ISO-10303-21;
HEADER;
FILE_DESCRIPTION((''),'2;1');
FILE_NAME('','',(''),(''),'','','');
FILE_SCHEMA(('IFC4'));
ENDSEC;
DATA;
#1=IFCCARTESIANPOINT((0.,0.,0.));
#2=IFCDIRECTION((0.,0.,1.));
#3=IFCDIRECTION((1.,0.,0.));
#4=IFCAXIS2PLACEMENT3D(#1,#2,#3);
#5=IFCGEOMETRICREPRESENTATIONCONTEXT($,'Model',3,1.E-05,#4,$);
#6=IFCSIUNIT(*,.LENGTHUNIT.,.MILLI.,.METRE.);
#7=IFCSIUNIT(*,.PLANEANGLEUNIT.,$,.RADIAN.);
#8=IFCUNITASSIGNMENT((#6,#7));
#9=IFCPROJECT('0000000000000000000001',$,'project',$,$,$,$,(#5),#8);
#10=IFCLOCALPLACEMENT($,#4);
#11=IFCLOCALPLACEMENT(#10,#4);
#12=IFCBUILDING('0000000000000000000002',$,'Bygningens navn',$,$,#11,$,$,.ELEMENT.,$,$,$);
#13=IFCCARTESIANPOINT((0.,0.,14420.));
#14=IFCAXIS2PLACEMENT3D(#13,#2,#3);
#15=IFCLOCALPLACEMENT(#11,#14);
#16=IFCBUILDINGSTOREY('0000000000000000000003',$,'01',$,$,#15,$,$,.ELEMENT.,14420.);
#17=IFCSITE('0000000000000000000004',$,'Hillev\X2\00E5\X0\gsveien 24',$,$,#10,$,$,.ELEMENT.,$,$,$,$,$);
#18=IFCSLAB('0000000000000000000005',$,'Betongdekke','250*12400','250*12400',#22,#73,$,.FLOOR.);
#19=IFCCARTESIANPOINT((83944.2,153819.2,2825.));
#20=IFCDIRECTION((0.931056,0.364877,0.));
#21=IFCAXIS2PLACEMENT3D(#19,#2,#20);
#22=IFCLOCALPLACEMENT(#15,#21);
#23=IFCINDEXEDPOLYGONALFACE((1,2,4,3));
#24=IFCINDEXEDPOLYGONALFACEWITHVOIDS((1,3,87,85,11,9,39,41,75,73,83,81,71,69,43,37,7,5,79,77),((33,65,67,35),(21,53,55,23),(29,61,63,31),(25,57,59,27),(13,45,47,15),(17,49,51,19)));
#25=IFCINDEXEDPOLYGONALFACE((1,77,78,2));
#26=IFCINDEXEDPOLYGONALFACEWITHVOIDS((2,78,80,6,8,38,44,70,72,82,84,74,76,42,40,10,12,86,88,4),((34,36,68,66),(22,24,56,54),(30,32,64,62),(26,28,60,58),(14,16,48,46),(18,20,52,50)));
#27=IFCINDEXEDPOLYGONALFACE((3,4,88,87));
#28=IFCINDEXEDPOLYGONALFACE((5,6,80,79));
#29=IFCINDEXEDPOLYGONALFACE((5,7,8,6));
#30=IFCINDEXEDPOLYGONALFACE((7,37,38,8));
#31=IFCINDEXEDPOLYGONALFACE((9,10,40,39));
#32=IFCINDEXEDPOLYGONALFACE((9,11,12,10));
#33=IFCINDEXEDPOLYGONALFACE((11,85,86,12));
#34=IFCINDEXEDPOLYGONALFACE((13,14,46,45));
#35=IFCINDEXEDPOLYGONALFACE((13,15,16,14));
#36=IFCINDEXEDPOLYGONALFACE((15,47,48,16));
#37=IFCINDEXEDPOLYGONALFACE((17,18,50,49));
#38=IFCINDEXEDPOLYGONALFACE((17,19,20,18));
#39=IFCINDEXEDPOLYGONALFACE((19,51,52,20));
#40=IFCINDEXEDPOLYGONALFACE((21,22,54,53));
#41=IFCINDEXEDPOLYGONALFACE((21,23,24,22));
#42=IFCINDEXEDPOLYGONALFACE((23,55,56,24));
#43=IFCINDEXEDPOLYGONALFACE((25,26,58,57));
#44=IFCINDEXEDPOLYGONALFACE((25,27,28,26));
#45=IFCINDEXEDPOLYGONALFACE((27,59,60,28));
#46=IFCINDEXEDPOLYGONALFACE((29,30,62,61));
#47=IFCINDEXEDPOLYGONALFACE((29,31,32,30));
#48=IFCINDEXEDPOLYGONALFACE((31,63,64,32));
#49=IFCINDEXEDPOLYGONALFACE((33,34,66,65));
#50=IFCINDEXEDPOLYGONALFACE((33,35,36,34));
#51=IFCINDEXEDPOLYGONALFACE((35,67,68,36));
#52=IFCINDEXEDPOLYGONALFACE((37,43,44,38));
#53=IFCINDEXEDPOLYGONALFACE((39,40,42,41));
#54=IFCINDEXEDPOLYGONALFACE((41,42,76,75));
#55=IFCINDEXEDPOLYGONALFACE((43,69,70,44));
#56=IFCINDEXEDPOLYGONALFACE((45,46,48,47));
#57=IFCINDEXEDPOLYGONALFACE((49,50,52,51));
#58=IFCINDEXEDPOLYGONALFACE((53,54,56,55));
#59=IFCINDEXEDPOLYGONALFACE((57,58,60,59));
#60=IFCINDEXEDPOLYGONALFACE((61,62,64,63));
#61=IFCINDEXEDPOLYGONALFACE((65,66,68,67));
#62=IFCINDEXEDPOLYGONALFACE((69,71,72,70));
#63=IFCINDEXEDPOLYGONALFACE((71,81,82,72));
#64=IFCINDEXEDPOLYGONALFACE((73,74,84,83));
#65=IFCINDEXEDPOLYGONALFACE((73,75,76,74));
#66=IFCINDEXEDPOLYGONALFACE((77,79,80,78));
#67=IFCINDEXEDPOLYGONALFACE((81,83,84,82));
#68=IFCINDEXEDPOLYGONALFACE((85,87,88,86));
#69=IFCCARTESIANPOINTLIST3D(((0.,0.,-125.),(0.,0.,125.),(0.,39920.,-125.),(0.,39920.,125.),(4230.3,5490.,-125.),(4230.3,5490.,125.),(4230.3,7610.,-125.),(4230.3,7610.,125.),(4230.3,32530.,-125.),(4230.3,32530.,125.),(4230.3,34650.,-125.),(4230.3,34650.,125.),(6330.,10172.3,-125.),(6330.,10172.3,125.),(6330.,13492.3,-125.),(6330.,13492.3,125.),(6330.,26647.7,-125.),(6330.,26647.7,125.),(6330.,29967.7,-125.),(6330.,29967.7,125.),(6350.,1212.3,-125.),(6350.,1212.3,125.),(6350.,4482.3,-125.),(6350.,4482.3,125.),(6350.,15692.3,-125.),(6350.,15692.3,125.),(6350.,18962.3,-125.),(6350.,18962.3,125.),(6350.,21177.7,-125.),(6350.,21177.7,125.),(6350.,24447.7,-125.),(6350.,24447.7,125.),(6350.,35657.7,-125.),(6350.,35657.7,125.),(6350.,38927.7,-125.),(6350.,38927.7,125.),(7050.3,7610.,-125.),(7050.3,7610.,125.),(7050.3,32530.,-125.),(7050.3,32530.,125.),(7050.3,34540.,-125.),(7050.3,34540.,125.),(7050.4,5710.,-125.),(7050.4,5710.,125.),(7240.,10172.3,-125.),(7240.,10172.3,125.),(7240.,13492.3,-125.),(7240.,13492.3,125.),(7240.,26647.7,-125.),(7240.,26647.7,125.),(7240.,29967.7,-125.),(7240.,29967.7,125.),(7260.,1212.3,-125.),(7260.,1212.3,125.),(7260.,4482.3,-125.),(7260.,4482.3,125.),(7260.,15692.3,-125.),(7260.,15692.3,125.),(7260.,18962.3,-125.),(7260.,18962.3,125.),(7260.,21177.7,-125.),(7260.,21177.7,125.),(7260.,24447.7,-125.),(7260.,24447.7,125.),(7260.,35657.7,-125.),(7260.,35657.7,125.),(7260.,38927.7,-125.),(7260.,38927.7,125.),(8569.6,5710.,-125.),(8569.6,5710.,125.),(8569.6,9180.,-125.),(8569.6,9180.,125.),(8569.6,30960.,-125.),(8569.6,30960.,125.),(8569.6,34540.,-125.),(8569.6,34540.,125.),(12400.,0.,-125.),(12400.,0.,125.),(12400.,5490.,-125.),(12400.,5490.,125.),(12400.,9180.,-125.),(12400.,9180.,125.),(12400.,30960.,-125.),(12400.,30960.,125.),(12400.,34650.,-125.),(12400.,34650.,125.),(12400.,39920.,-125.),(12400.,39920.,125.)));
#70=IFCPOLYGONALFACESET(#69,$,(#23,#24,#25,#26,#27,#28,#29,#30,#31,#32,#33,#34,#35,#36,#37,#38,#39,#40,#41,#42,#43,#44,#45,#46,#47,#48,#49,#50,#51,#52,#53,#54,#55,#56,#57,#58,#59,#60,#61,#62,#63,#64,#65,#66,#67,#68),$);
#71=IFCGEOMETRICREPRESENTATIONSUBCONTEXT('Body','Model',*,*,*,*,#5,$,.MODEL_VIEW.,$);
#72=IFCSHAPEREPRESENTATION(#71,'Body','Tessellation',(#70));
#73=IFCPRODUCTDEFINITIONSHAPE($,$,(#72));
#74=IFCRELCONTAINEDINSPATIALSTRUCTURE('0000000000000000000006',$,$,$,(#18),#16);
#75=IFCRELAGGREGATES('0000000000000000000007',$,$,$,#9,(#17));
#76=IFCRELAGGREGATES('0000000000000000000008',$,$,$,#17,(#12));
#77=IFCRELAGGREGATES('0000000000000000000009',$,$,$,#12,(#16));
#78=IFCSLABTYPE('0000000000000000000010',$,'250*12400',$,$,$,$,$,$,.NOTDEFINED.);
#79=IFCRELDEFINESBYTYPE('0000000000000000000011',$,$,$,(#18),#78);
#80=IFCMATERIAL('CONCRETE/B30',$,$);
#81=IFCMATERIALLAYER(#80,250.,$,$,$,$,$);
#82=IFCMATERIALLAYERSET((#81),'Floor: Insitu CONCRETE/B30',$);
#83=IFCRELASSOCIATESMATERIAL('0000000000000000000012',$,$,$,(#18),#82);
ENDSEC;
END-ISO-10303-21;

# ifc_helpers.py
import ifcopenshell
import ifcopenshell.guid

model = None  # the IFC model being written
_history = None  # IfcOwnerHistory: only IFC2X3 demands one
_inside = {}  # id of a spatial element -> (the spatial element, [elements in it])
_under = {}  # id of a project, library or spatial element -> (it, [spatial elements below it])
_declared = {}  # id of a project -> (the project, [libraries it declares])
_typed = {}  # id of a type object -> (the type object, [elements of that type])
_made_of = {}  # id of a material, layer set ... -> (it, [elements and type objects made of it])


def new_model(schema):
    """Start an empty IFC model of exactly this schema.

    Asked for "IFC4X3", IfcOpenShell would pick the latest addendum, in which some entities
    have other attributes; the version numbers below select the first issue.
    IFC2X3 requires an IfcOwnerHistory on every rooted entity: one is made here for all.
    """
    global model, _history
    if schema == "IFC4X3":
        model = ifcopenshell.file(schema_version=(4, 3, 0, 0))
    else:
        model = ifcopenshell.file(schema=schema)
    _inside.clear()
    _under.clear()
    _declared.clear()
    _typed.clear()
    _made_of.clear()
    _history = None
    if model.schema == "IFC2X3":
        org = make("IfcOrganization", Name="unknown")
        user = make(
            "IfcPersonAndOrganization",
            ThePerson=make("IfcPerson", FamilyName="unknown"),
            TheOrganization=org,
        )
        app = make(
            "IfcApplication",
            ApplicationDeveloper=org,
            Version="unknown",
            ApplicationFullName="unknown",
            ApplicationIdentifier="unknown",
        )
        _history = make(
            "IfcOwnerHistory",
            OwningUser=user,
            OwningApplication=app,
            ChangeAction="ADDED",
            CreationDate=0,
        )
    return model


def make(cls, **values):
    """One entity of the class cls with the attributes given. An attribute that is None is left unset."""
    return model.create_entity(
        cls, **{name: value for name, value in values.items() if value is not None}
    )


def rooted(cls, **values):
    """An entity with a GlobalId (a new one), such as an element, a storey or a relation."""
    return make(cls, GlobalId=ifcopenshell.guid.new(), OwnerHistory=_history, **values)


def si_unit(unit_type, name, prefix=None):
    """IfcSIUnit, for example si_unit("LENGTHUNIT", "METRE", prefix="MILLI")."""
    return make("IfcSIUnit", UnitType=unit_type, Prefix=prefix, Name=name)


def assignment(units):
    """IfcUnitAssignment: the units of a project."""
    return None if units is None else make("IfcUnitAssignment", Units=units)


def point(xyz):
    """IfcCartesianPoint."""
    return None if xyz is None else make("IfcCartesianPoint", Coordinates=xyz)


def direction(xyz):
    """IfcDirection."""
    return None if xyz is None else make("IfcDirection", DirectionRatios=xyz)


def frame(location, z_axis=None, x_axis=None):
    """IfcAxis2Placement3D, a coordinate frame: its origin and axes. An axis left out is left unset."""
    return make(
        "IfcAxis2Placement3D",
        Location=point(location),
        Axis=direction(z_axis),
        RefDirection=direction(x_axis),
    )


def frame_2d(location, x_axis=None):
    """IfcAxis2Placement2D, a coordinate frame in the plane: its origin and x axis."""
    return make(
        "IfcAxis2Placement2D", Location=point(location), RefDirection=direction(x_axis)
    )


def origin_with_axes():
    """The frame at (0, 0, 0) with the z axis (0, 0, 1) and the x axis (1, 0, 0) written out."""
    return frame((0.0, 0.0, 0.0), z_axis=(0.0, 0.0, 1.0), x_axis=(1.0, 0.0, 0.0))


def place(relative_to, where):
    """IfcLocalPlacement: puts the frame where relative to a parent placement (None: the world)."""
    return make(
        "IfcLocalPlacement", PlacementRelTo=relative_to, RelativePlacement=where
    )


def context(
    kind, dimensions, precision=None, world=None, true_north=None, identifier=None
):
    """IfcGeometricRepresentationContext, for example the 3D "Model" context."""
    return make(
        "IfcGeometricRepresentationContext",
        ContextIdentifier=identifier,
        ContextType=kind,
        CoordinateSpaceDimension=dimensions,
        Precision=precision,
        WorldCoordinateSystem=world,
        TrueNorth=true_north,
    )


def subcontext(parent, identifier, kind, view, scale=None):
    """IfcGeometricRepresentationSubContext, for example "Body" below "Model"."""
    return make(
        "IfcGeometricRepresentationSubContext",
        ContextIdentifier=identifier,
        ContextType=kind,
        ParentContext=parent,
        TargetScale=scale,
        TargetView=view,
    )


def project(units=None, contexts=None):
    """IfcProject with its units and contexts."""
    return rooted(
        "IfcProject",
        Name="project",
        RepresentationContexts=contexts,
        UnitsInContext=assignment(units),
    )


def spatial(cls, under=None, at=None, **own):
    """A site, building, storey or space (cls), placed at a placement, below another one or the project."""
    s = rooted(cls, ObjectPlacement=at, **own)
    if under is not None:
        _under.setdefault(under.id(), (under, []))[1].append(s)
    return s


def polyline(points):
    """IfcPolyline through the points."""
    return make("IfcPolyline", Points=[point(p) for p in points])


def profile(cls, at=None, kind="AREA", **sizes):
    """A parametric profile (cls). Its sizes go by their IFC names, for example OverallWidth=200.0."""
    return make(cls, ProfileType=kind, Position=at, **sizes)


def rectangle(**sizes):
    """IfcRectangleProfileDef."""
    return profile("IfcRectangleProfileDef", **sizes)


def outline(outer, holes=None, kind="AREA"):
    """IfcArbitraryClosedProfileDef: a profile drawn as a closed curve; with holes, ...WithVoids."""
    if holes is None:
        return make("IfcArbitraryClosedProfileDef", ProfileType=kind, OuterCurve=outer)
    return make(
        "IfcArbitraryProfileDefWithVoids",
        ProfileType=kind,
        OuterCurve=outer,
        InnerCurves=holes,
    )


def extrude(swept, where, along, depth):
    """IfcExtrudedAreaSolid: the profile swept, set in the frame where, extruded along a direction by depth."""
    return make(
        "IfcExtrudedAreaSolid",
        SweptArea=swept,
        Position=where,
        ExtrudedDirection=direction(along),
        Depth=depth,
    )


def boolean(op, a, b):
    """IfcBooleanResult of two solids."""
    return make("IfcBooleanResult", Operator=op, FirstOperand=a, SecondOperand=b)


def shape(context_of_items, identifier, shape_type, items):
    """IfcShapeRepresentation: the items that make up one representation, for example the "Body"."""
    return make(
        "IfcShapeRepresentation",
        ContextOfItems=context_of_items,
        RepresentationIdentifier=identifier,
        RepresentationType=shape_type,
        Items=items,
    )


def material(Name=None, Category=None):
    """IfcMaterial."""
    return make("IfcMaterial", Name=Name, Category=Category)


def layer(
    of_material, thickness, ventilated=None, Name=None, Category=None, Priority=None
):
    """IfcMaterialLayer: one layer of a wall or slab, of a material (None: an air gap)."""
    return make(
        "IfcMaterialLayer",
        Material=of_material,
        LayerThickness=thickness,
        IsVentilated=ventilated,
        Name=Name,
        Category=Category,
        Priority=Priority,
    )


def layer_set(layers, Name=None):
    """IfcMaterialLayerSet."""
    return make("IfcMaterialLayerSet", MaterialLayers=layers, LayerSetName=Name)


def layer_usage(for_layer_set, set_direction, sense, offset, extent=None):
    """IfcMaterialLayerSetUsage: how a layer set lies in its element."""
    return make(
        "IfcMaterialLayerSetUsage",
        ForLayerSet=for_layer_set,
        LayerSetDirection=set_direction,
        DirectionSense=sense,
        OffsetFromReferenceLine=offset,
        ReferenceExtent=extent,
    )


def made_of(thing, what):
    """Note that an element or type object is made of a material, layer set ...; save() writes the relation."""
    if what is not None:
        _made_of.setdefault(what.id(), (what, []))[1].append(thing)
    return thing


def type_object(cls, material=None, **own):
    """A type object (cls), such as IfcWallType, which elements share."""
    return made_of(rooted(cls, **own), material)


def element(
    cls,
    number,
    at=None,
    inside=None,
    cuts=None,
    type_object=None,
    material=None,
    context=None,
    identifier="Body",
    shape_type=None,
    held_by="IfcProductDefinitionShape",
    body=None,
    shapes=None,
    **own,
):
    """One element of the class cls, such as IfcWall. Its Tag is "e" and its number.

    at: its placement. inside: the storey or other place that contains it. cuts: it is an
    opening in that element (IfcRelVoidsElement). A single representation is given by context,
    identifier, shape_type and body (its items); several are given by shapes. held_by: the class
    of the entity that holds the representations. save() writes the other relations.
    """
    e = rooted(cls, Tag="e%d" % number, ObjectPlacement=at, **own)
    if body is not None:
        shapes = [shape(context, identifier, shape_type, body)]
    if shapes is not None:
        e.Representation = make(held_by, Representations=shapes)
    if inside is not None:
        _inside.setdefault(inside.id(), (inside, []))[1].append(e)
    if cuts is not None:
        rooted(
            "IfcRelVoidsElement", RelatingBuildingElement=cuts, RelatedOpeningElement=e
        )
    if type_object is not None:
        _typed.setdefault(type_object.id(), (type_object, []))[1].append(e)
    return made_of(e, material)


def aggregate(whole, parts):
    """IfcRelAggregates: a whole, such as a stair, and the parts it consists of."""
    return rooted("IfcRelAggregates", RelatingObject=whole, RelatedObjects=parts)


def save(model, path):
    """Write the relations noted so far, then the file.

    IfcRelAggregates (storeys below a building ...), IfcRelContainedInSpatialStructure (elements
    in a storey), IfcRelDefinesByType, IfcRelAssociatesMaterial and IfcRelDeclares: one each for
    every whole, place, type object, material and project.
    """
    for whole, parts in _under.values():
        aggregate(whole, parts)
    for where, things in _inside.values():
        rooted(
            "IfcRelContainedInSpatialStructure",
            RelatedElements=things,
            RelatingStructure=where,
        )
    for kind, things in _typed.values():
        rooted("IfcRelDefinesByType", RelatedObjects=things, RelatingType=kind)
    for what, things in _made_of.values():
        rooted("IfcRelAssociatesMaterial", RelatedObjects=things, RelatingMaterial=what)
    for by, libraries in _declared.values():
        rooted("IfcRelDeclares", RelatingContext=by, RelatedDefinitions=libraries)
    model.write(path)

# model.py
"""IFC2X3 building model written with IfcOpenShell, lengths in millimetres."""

from ifc_helpers import new_model, si_unit, frame, frame_2d, origin_with_axes, place, context, subcontext, project, spatial, polyline, rectangle, outline, extrude, boolean, material, layer, layer_set, layer_usage, type_object, element, save


model = new_model("IFC2X3")

# Units and contexts
model_context = context("Model", 3, precision=1e-05, world=origin_with_axes())
body_context = subcontext(model_context, "Body", "Model", "MODEL_VIEW")
ifc_project = project(units=[si_unit("LENGTHUNIT", "METRE", prefix="MILLI"), si_unit("PLANEANGLEUNIT", "RADIAN")], contexts=[model_context])

# Site, building, storey
site_placement = place(None, origin_with_axes())
site = spatial("IfcSite", under=ifc_project, at=site_placement, Name="Hillevågsveien 24", CompositionType="ELEMENT")
building_placement = place(site_placement, origin_with_axes())
building = spatial("IfcBuilding", under=site, at=building_placement, Name="Bygningens navn", CompositionType="ELEMENT")
storey_placement = place(building_placement, frame((0.0, 0.0, 14420.0), z_axis=(0.0, 0.0, 1.0), x_axis=(1.0, 0.0, 0.0)))
storey = spatial("IfcBuildingStorey", under=building, at=storey_placement, Name="01", CompositionType="ELEMENT", Elevation=14420.0)

# Slab
ifc_material_1 = material(Name="CONCRETE/B30")
ifc_layer_1 = layer(ifc_material_1, 250.0)
ifc_layer_set_1 = layer_set([ifc_layer_1], Name="Floor: Insitu CONCRETE/B30")
ifc_layer_usage_1 = layer_usage(ifc_layer_set_1, "AXIS3", "POSITIVE", -125.0)
slab_type_1 = type_object("IfcSlabType", Name="250*12400", PredefinedType="NOTDEFINED")
slab_1_placement = place(storey_placement, frame((83944.2, 153819.2, 2825.0), z_axis=(0.0, 0.0, 1.0), x_axis=(0.931056, 0.364877, 0.0)))
element("IfcSlab", 1, at=slab_1_placement, inside=storey, type_object=slab_type_1, material=ifc_layer_usage_1, Name="Betongdekke", Description="250*12400", ObjectType="250*12400", PredefinedType="FLOOR", context=body_context, shape_type="CSG", body=[
    boolean("DIFFERENCE", boolean("DIFFERENCE", boolean("DIFFERENCE", boolean("DIFFERENCE", boolean("DIFFERENCE", boolean("DIFFERENCE", extrude(outline(polyline([(0.0, 0.0), (12400.0, 0.0), (12400.0, 5490.0), (4230.3, 5490.0), (4230.3, 7610.0), (7050.3, 7610.0), (7050.4, 5710.0), (8569.6, 5710.0), (8569.6, 9180.0), (12400.0, 9180.0), (12400.0, 23510.0), (12400.0, 30960.0), (8569.6, 30960.0), (8569.6, 34540.0), (7050.3, 34540.0), (7050.3, 32530.0), (4230.3, 32530.0), (4230.3, 34650.0), (12400.0, 34650.0), (12400.0, 39920.0), (0.0, 39920.0), (0.0, 0.0)])), frame((0.0, 0.0, -125.0), z_axis=(0.0, 0.0, 1.0), x_axis=(1.0, 0.0, 0.0)), (0.0, 0.0, 1.0), 250.0), extrude(rectangle(XDim=3270.0, YDim=910.0, at=frame_2d((0.0, 0.0), x_axis=(1.0, 0.0))), frame((6805.0, 37292.7, -145.0), z_axis=(0.0, 0.0, 1.0), x_axis=(0.0, -1.0, 0.0)), (0.0, 0.0, 1.0), 320.0)), extrude(rectangle(XDim=3270.0, YDim=910.0, at=frame_2d((0.0, 0.0), x_axis=(1.0, 0.0))), frame((6805.0, 2847.3, -145.0), z_axis=(0.0, 0.0, 1.0), x_axis=(0.0, -1.0, 0.0)), (0.0, 0.0, 1.0), 320.0)), extrude(rectangle(XDim=3270.0, YDim=910.0, at=frame_2d((0.0, 0.0), x_axis=(1.0, 0.0))), frame((6805.0, 22812.7, -145.0), z_axis=(0.0, 0.0, 1.0), x_axis=(0.0, -1.0, 0.0)), (0.0, 0.0, 1.0), 320.0)), extrude(rectangle(XDim=3320.0, YDim=910.0, at=frame_2d((0.0, 0.0), x_axis=(1.0, 0.0))), frame((6785.0, 28307.7, -145.0), z_axis=(0.0, 0.0, 1.0), x_axis=(0.0, -1.0, 0.0)), (0.0, 0.0, 1.0), 320.0)), extrude(rectangle(XDim=3270.0, YDim=910.0, at=frame_2d((0.0, 0.0), x_axis=(1.0, 0.0))), frame((6805.0, 17327.3, -145.0), z_axis=(0.0, 0.0, 1.0), x_axis=(0.0, -1.0, 0.0)), (0.0, 0.0, 1.0), 320.0)), extrude(rectangle(XDim=3320.0, YDim=910.0, at=frame_2d((0.0, 0.0), x_axis=(1.0, 0.0))), frame((6785.0, 11832.3, -145.0), z_axis=(0.0, 0.0, 1.0), x_axis=(0.0, -1.0, 0.0)), (0.0, 0.0, 1.0), 320.0)),
])

save(model, "model.ifc")
